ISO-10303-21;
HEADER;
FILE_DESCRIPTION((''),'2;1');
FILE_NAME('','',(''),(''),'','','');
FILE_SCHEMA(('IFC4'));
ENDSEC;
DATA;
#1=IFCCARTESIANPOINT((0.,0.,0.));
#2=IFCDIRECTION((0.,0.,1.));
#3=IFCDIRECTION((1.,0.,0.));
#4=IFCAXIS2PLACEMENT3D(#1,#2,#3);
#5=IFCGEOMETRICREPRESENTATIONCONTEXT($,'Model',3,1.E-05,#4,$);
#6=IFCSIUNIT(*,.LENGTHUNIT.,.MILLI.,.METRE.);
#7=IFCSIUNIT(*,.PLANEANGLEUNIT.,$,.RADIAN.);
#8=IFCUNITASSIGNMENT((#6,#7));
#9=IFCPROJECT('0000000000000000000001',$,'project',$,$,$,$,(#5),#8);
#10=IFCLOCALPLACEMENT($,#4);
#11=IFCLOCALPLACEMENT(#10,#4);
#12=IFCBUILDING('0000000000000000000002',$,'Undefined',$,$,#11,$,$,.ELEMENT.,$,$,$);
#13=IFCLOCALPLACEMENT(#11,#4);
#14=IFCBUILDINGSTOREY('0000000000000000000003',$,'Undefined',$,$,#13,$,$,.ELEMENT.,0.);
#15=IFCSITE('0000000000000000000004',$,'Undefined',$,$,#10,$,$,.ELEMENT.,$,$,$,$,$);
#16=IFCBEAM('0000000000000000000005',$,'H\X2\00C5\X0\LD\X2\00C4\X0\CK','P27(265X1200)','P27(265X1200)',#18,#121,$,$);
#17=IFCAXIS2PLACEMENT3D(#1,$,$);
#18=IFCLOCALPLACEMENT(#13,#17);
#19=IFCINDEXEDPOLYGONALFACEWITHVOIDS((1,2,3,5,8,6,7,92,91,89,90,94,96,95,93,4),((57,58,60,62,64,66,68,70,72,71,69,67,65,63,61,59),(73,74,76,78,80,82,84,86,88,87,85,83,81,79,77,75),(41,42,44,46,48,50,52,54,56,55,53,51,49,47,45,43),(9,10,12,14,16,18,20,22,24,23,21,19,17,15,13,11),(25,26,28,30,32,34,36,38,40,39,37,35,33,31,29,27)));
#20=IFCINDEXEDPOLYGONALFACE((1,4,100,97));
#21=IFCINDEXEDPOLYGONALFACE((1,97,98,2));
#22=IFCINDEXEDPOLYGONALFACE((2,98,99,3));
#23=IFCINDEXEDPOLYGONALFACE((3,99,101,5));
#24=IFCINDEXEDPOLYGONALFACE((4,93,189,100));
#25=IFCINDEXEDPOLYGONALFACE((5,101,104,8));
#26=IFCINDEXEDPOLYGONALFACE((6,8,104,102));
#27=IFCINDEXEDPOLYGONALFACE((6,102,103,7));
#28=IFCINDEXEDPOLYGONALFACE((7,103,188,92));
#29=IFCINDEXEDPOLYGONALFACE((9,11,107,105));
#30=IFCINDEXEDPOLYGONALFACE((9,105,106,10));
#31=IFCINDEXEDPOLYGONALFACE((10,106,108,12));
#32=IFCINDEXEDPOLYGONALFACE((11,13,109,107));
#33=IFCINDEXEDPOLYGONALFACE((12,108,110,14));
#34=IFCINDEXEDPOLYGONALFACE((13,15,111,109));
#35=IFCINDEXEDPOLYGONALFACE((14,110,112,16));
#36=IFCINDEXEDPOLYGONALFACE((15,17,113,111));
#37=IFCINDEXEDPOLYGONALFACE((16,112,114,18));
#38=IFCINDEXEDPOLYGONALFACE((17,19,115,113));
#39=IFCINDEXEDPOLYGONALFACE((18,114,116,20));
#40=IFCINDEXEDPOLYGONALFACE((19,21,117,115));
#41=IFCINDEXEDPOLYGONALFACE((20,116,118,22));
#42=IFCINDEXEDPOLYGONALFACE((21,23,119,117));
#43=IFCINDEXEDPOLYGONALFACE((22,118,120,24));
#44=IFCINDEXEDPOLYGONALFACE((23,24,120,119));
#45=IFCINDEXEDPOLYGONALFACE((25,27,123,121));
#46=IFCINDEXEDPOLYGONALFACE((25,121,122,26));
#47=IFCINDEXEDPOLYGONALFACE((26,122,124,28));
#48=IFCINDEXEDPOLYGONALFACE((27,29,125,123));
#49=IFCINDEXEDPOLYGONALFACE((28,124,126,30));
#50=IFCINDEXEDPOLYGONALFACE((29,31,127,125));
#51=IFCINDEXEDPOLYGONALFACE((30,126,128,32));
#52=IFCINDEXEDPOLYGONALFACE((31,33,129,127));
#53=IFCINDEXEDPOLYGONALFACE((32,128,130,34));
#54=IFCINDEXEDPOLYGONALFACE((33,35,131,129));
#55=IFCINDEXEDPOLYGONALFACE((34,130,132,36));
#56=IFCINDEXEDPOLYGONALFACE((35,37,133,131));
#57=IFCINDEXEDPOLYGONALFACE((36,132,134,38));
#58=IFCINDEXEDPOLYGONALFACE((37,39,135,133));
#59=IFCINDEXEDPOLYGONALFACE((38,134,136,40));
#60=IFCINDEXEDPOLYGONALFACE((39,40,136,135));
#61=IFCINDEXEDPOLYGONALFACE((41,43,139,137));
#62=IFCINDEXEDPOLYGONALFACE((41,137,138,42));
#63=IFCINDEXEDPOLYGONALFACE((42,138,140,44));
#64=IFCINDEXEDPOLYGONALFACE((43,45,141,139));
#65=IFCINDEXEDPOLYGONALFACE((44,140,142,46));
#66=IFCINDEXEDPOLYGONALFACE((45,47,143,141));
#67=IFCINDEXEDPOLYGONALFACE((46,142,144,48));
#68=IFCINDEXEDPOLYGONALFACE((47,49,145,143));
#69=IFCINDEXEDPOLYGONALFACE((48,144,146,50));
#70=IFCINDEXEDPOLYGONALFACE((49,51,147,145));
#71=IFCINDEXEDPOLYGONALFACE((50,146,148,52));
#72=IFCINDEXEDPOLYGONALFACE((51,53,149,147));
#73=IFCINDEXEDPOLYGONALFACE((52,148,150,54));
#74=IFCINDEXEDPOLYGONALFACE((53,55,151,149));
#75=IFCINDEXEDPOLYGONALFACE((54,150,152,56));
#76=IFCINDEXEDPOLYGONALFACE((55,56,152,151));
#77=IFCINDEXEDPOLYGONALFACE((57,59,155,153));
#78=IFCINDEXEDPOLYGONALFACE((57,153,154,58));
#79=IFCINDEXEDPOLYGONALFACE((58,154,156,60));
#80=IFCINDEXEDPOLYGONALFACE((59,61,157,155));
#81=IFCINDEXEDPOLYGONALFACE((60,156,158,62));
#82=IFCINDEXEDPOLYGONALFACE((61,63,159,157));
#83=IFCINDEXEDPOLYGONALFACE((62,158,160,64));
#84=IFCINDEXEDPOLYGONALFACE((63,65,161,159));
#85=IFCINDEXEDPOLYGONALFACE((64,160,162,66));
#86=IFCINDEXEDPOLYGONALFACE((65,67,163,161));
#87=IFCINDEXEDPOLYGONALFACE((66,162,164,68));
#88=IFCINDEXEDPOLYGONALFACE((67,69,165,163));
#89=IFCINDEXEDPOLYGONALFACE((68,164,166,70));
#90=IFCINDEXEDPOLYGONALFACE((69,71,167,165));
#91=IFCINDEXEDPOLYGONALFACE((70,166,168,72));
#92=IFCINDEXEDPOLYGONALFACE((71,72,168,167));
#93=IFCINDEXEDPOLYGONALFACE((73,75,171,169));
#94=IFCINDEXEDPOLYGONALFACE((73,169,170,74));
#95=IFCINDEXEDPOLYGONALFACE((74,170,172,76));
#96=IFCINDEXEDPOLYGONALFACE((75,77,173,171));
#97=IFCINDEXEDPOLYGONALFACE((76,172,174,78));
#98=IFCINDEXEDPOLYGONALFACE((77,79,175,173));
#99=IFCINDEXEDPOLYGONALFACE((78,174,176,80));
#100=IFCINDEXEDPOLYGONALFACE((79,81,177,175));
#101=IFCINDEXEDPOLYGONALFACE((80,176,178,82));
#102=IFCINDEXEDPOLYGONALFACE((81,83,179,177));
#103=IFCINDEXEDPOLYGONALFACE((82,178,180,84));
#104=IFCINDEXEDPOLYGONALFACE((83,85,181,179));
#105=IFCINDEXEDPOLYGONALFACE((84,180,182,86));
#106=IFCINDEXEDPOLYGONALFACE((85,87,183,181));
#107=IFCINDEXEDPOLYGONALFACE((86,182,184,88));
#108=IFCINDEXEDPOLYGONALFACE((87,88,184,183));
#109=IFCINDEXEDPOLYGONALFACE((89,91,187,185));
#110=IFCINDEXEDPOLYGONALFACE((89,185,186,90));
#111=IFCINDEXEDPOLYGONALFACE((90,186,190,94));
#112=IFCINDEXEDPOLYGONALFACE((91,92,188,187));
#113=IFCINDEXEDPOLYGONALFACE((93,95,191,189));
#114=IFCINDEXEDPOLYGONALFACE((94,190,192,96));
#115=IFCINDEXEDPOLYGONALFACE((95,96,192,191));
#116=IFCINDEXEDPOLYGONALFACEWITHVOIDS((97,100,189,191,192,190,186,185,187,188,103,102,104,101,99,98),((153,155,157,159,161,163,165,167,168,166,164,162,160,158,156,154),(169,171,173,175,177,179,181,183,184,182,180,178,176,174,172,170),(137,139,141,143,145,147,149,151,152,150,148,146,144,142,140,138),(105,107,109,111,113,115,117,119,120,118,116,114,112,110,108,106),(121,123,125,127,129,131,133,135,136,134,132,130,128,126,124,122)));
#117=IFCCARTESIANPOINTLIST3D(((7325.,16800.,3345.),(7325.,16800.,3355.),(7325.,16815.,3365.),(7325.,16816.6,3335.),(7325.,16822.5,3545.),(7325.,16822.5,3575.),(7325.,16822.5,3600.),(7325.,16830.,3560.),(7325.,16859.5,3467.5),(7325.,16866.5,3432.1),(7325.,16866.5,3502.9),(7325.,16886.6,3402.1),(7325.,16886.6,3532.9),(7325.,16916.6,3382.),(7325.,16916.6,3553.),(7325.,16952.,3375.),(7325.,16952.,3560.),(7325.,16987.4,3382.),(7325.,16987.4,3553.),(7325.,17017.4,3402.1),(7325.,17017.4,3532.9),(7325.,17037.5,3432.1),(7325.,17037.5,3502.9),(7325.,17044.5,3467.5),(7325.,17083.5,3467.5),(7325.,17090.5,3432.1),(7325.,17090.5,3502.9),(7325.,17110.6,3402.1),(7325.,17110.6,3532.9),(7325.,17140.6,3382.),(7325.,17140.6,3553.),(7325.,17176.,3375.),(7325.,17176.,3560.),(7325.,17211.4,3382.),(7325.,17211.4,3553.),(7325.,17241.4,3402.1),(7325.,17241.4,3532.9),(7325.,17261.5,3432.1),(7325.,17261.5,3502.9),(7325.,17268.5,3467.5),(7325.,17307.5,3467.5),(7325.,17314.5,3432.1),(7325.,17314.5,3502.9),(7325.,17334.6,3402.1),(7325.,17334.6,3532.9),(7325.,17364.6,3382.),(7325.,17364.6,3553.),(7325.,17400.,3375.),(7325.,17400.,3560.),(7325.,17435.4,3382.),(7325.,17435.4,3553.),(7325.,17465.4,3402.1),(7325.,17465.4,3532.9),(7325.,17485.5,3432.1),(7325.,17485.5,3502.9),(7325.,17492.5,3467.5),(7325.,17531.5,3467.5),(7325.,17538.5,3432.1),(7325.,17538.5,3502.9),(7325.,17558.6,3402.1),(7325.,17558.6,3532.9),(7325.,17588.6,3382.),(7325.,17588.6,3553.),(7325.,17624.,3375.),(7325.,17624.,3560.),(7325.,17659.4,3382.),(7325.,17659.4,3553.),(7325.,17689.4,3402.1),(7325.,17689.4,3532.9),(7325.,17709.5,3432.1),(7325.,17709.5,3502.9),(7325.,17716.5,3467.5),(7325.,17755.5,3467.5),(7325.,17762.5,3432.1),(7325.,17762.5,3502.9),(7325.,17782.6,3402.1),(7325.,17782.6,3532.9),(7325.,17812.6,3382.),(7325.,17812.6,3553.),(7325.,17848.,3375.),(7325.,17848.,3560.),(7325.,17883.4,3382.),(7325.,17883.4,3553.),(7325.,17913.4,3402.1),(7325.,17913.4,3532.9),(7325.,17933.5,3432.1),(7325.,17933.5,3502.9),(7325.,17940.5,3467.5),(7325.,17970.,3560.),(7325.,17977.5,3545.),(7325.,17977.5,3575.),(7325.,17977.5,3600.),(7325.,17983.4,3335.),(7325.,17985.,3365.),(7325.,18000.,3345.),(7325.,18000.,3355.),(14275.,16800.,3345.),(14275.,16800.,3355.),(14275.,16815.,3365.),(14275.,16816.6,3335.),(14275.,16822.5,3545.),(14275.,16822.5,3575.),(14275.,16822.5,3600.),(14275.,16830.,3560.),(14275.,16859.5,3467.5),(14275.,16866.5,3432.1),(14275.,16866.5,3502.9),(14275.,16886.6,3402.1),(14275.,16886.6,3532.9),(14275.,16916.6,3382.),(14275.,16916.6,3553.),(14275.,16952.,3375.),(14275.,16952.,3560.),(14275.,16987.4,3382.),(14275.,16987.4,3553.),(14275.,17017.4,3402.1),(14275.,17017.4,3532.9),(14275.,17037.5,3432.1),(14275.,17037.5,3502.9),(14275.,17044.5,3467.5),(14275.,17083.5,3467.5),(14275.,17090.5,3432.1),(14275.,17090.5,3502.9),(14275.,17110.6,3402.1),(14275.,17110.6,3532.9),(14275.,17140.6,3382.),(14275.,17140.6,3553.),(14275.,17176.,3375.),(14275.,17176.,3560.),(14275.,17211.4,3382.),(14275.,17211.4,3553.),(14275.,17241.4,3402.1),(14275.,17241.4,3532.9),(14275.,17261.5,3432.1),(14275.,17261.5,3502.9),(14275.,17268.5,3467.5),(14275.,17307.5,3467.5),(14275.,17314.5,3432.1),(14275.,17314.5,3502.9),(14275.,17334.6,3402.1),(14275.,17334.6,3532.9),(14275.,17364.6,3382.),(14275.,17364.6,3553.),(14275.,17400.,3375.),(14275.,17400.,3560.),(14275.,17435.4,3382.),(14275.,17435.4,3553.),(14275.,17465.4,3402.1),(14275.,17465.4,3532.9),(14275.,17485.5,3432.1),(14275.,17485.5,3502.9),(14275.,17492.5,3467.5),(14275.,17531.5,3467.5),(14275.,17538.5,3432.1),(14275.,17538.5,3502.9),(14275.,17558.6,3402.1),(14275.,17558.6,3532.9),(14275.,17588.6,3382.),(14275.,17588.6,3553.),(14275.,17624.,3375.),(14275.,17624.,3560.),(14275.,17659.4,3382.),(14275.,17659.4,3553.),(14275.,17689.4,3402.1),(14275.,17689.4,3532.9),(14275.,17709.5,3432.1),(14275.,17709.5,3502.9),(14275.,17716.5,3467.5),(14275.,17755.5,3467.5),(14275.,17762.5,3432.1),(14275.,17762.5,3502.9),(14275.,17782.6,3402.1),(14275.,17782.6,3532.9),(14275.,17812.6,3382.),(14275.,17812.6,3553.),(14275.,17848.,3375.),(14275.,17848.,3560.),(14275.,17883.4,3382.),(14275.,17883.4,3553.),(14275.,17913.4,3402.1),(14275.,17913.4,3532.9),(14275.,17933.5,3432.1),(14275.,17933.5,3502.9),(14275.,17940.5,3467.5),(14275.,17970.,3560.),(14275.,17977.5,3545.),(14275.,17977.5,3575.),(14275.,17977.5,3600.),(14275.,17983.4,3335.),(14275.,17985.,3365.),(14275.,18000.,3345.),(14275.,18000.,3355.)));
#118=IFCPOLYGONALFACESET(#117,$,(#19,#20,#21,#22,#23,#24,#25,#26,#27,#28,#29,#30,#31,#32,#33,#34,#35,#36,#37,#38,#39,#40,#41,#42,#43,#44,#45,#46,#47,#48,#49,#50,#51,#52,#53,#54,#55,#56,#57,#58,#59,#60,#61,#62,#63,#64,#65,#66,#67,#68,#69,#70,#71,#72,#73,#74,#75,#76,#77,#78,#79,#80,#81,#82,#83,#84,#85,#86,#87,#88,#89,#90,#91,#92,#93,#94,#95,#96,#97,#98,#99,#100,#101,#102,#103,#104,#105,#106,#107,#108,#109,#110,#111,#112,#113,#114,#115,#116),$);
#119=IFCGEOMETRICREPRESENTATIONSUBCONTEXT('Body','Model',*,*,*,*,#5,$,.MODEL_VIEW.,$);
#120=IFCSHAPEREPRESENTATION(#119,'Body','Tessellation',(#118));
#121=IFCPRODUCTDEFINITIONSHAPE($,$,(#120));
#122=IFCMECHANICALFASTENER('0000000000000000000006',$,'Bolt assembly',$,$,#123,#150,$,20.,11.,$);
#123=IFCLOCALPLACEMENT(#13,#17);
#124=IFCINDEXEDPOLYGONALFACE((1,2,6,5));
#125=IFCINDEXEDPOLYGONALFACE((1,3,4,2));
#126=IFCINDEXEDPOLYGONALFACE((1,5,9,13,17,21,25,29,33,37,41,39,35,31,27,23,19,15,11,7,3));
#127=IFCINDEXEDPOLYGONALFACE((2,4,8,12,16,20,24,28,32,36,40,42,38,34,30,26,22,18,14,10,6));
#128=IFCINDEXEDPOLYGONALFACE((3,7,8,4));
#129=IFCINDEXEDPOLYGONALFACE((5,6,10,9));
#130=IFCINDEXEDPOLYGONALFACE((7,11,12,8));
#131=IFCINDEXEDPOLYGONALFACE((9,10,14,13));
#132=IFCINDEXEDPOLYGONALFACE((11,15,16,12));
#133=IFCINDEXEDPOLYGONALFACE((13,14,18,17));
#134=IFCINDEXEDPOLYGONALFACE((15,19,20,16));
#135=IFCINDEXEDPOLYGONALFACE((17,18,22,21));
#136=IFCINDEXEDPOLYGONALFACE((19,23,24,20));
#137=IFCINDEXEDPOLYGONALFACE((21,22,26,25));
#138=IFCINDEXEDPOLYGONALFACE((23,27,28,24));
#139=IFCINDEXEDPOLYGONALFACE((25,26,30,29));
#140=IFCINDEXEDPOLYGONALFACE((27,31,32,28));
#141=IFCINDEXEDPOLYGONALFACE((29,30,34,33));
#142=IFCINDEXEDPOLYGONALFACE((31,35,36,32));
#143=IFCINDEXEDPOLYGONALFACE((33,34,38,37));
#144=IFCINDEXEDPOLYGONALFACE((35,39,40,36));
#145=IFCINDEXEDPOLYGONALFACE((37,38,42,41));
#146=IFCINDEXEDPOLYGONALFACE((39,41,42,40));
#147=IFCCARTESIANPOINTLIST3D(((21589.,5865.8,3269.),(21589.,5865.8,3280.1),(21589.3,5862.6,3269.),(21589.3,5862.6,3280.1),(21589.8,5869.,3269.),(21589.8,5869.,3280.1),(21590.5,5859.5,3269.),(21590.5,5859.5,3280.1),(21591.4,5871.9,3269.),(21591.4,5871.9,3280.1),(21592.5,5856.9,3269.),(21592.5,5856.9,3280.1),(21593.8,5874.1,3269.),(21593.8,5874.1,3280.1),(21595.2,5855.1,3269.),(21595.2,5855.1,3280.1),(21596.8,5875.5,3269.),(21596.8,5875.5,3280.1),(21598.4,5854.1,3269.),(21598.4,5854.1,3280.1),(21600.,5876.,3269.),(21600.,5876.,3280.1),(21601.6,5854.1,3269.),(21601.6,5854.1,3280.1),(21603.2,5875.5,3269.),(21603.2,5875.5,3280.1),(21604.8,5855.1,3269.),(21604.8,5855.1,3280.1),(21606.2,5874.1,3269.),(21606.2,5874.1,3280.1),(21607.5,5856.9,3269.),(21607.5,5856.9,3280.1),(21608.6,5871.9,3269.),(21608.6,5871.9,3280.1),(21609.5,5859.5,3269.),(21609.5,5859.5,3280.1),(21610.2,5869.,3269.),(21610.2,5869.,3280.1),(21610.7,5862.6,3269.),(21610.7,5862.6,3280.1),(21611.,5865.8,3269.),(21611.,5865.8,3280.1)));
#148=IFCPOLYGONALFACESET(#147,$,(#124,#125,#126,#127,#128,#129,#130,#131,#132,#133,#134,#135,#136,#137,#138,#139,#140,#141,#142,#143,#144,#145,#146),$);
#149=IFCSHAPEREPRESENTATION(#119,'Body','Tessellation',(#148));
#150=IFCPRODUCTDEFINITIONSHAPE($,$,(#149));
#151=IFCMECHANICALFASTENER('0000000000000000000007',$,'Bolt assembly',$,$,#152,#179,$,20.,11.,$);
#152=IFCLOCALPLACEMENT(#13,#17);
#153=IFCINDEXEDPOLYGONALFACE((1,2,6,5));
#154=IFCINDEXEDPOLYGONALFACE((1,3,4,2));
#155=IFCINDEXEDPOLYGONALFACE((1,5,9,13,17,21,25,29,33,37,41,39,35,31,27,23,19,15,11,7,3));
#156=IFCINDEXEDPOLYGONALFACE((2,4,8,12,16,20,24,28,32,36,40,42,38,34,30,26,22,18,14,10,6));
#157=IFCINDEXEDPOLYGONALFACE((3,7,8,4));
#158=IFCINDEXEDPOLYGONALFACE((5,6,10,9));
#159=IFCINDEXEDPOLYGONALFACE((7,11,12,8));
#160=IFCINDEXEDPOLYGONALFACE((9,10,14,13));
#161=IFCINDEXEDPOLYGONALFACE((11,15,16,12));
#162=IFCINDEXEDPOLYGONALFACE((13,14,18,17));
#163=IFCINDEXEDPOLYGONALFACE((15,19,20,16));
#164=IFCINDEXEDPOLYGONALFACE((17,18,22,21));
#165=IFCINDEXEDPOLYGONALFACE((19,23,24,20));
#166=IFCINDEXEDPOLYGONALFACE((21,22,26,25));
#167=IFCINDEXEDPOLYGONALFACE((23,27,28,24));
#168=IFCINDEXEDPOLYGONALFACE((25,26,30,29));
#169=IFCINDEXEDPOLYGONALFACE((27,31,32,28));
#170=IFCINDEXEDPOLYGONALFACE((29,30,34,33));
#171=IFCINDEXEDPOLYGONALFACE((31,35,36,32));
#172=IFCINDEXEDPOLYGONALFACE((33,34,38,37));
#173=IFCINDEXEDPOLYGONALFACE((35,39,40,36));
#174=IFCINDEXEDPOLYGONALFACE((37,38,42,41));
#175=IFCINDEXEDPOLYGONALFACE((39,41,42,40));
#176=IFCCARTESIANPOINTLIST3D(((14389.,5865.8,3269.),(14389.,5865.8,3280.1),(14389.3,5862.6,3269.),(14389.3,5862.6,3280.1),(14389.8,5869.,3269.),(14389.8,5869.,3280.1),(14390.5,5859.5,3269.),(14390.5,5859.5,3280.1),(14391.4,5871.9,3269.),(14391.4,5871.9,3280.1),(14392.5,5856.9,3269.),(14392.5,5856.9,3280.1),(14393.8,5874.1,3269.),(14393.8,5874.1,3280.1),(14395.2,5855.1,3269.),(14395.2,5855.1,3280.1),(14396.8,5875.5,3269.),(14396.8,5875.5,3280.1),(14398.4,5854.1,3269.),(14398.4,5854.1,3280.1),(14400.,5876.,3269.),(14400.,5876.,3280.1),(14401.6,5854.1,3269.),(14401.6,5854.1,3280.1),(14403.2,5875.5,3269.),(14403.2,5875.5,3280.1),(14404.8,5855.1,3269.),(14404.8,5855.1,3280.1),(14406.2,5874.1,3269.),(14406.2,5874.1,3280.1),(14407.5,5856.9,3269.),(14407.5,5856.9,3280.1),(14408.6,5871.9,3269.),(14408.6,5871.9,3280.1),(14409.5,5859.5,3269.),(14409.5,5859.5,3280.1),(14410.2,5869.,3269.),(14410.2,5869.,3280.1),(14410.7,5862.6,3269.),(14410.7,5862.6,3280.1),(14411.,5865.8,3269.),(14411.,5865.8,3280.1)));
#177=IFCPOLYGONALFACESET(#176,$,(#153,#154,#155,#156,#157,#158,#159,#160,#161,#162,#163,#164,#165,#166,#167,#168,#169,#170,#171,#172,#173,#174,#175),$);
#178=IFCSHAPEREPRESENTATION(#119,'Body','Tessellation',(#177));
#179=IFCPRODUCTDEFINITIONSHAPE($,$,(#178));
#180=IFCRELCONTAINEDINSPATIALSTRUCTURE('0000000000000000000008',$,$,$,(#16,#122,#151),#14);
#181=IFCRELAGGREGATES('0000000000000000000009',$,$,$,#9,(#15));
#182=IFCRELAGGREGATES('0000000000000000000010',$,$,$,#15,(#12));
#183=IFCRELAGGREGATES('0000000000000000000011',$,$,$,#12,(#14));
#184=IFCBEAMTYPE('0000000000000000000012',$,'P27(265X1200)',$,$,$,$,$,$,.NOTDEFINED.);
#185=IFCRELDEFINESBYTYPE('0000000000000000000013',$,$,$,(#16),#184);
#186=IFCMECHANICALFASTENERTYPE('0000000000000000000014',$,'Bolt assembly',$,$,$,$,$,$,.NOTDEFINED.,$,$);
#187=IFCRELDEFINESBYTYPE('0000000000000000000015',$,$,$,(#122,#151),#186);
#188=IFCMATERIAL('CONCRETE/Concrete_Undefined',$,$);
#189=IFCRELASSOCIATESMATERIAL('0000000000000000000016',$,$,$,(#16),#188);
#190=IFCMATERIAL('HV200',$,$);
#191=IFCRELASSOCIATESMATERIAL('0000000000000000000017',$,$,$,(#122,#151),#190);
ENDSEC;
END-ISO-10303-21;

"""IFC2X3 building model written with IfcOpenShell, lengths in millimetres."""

from ifc_helpers import new_model, si_unit, frame, origin_with_axes, origin_2d_with_axis, place, context, subcontext, project, spatial, polyline, circle, outline, extrude, source, transform, mapped, material, type_object, element, save


model = new_model("IFC2X3")

# Units and contexts
model_context = context("Model", 3, precision=1e-05, world=origin_with_axes())
body_context = subcontext(model_context, "Body", "Model", "MODEL_VIEW")
ifc_project = project(units=[si_unit("LENGTHUNIT", "METRE", prefix="MILLI"), si_unit("PLANEANGLEUNIT", "RADIAN")], contexts=[model_context])

# Site, building, storey
site_placement = place(None, origin_with_axes())
site = spatial("IfcSite", under=ifc_project, at=site_placement, Name="Undefined", CompositionType="ELEMENT")
building_placement = place(site_placement, origin_with_axes())
building = spatial("IfcBuilding", under=site, at=building_placement, Name="Undefined", CompositionType="ELEMENT")
storey_placement = place(building_placement, origin_with_axes())
storey = spatial("IfcBuildingStorey", under=building, at=storey_placement, Name="Undefined", CompositionType="ELEMENT", Elevation=0.0)

# Beam
ifc_material_1 = material(Name="CONCRETE/Concrete_Undefined")
beam_type_1 = type_object("IfcBeamType", Name="P27(265X1200)", PredefinedType="NOTDEFINED")
beam_1_placement = place(storey_placement, frame((7325.0, 17400.0, 3467.5), z_axis=(0.0, 0.0, 1.0), x_axis=(1.0, 0.0, 0.0)))
element("IfcBeam", 1, at=beam_1_placement, inside=storey, type_object=beam_type_1, material=ifc_material_1, Name="HÅLDÄCK", Description="P27(265X1200)", ObjectType="P27(265X1200)", context=body_context, shape_type="SweptSolid", body=[
    extrude(outline(polyline([(-583.4, -132.5), (-600.0, -122.5), (-600.0, -112.5), (-585.0, -102.5), (-577.5, 77.5), (-570.0, 92.5), (-577.5, 107.5), (-577.5, 132.5), (577.5, 132.5), (577.5, 107.5), (570.0, 92.5), (577.5, 77.5), (585.0, -102.5), (600.0, -112.5), (600.0, -122.5), (583.4, -132.5), (-583.4, -132.5)]), holes=[polyline([(-513.4, 65.4), (-533.5, 35.4), (-540.5, 0.0), (-533.5, -35.4), (-513.4, -65.4), (-483.4, -85.5), (-448.0, -92.5), (-412.6, -85.5), (-382.6, -65.4), (-362.5, -35.4), (-355.5, 0.0), (-362.5, 35.4), (-382.6, 65.4), (-412.6, 85.5), (-448.0, 92.5), (-483.4, 85.5), (-513.4, 65.4)]), polyline([(-289.4, 65.4), (-309.5, 35.4), (-316.5, 0.0), (-309.5, -35.4), (-289.4, -65.4), (-259.4, -85.5), (-224.0, -92.5), (-188.6, -85.5), (-158.6, -65.4), (-138.5, -35.4), (-131.5, 0.0), (-138.5, 35.4), (-158.6, 65.4), (-188.6, 85.5), (-224.0, 92.5), (-259.4, 85.5), (-289.4, 65.4)]), polyline([(-65.4, 65.4), (-85.5, 35.4), (-92.5, 0.0), (-85.5, -35.4), (-65.4, -65.4), (-35.4, -85.5), (0.0, -92.5), (35.4, -85.5), (65.4, -65.4), (85.5, -35.4), (92.5, 0.0), (85.5, 35.4), (65.4, 65.4), (35.4, 85.5), (0.0, 92.5), (-35.4, 85.5), (-65.4, 65.4)]), polyline([(158.6, 65.4), (138.5, 35.4), (131.5, 0.0), (138.5, -35.4), (158.6, -65.4), (188.6, -85.5), (224.0, -92.5), (259.4, -85.5), (289.4, -65.4), (309.5, -35.4), (316.5, 0.0), (309.5, 35.4), (289.4, 65.4), (259.4, 85.5), (224.0, 92.5), (188.6, 85.5), (158.6, 65.4)]), polyline([(382.6, 65.4), (362.5, 35.4), (355.5, 0.0), (362.5, -35.4), (382.6, -65.4), (412.6, -85.5), (448.0, -92.5), (483.4, -85.5), (513.4, -65.4), (533.5, -35.4), (540.5, 0.0), (533.5, 35.4), (513.4, 65.4), (483.4, 85.5), (448.0, 92.5), (412.6, 85.5), (382.6, 65.4)])]), frame((6950.0, 0.0, 0.0), z_axis=(-1.0, 0.0, 0.0), x_axis=(0.0, -1.0, 0.0)), (0.0, 0.0, 1.0), 6950.0),
])

# Mechanical fasteners
ifc_material_2 = material(Name="HV200")
mechanical_fastener_type = type_object("IfcMechanicalFastenerType", Name="Bolt assembly")
shared_shape_1 = source(origin_with_axes(), body_context, "Body", "SweptSolid", [
    extrude(circle(Radius=11.0, at=origin_2d_with_axis()), frame((0.0, -11.0, 0.0), z_axis=(0.0, 1.0, 0.0), x_axis=(1.0, 0.0, 0.0)), (0.0, 0.0, 1.0), 11.1),
])
for number, where, z_axis, x_axis, name in (
    (2, (21600.0, 5865.0, 3280.0), (1.0, 0.0, 0.0), (0.0, 1.0, 0.0), "Bolt assembly"),
    (3, (14400.0, 5865.0, 3280.0), (1.0, 0.0, 0.0), (0.0, 1.0, 0.0), "Bolt assembly"),
):
    element("IfcMechanicalFastener", number, at=place(storey_placement, frame(where, z_axis=z_axis, x_axis=x_axis)), inside=storey, type_object=mechanical_fastener_type, material=ifc_material_2, Name=name, NominalDiameter=20.0, NominalLength=11.0, context=body_context, shape_type="MappedRepresentation", body=[
        mapped(shared_shape_1, transform((0.0, 0.0, 0.0))),
    ])

save(model, "model.ifc")
